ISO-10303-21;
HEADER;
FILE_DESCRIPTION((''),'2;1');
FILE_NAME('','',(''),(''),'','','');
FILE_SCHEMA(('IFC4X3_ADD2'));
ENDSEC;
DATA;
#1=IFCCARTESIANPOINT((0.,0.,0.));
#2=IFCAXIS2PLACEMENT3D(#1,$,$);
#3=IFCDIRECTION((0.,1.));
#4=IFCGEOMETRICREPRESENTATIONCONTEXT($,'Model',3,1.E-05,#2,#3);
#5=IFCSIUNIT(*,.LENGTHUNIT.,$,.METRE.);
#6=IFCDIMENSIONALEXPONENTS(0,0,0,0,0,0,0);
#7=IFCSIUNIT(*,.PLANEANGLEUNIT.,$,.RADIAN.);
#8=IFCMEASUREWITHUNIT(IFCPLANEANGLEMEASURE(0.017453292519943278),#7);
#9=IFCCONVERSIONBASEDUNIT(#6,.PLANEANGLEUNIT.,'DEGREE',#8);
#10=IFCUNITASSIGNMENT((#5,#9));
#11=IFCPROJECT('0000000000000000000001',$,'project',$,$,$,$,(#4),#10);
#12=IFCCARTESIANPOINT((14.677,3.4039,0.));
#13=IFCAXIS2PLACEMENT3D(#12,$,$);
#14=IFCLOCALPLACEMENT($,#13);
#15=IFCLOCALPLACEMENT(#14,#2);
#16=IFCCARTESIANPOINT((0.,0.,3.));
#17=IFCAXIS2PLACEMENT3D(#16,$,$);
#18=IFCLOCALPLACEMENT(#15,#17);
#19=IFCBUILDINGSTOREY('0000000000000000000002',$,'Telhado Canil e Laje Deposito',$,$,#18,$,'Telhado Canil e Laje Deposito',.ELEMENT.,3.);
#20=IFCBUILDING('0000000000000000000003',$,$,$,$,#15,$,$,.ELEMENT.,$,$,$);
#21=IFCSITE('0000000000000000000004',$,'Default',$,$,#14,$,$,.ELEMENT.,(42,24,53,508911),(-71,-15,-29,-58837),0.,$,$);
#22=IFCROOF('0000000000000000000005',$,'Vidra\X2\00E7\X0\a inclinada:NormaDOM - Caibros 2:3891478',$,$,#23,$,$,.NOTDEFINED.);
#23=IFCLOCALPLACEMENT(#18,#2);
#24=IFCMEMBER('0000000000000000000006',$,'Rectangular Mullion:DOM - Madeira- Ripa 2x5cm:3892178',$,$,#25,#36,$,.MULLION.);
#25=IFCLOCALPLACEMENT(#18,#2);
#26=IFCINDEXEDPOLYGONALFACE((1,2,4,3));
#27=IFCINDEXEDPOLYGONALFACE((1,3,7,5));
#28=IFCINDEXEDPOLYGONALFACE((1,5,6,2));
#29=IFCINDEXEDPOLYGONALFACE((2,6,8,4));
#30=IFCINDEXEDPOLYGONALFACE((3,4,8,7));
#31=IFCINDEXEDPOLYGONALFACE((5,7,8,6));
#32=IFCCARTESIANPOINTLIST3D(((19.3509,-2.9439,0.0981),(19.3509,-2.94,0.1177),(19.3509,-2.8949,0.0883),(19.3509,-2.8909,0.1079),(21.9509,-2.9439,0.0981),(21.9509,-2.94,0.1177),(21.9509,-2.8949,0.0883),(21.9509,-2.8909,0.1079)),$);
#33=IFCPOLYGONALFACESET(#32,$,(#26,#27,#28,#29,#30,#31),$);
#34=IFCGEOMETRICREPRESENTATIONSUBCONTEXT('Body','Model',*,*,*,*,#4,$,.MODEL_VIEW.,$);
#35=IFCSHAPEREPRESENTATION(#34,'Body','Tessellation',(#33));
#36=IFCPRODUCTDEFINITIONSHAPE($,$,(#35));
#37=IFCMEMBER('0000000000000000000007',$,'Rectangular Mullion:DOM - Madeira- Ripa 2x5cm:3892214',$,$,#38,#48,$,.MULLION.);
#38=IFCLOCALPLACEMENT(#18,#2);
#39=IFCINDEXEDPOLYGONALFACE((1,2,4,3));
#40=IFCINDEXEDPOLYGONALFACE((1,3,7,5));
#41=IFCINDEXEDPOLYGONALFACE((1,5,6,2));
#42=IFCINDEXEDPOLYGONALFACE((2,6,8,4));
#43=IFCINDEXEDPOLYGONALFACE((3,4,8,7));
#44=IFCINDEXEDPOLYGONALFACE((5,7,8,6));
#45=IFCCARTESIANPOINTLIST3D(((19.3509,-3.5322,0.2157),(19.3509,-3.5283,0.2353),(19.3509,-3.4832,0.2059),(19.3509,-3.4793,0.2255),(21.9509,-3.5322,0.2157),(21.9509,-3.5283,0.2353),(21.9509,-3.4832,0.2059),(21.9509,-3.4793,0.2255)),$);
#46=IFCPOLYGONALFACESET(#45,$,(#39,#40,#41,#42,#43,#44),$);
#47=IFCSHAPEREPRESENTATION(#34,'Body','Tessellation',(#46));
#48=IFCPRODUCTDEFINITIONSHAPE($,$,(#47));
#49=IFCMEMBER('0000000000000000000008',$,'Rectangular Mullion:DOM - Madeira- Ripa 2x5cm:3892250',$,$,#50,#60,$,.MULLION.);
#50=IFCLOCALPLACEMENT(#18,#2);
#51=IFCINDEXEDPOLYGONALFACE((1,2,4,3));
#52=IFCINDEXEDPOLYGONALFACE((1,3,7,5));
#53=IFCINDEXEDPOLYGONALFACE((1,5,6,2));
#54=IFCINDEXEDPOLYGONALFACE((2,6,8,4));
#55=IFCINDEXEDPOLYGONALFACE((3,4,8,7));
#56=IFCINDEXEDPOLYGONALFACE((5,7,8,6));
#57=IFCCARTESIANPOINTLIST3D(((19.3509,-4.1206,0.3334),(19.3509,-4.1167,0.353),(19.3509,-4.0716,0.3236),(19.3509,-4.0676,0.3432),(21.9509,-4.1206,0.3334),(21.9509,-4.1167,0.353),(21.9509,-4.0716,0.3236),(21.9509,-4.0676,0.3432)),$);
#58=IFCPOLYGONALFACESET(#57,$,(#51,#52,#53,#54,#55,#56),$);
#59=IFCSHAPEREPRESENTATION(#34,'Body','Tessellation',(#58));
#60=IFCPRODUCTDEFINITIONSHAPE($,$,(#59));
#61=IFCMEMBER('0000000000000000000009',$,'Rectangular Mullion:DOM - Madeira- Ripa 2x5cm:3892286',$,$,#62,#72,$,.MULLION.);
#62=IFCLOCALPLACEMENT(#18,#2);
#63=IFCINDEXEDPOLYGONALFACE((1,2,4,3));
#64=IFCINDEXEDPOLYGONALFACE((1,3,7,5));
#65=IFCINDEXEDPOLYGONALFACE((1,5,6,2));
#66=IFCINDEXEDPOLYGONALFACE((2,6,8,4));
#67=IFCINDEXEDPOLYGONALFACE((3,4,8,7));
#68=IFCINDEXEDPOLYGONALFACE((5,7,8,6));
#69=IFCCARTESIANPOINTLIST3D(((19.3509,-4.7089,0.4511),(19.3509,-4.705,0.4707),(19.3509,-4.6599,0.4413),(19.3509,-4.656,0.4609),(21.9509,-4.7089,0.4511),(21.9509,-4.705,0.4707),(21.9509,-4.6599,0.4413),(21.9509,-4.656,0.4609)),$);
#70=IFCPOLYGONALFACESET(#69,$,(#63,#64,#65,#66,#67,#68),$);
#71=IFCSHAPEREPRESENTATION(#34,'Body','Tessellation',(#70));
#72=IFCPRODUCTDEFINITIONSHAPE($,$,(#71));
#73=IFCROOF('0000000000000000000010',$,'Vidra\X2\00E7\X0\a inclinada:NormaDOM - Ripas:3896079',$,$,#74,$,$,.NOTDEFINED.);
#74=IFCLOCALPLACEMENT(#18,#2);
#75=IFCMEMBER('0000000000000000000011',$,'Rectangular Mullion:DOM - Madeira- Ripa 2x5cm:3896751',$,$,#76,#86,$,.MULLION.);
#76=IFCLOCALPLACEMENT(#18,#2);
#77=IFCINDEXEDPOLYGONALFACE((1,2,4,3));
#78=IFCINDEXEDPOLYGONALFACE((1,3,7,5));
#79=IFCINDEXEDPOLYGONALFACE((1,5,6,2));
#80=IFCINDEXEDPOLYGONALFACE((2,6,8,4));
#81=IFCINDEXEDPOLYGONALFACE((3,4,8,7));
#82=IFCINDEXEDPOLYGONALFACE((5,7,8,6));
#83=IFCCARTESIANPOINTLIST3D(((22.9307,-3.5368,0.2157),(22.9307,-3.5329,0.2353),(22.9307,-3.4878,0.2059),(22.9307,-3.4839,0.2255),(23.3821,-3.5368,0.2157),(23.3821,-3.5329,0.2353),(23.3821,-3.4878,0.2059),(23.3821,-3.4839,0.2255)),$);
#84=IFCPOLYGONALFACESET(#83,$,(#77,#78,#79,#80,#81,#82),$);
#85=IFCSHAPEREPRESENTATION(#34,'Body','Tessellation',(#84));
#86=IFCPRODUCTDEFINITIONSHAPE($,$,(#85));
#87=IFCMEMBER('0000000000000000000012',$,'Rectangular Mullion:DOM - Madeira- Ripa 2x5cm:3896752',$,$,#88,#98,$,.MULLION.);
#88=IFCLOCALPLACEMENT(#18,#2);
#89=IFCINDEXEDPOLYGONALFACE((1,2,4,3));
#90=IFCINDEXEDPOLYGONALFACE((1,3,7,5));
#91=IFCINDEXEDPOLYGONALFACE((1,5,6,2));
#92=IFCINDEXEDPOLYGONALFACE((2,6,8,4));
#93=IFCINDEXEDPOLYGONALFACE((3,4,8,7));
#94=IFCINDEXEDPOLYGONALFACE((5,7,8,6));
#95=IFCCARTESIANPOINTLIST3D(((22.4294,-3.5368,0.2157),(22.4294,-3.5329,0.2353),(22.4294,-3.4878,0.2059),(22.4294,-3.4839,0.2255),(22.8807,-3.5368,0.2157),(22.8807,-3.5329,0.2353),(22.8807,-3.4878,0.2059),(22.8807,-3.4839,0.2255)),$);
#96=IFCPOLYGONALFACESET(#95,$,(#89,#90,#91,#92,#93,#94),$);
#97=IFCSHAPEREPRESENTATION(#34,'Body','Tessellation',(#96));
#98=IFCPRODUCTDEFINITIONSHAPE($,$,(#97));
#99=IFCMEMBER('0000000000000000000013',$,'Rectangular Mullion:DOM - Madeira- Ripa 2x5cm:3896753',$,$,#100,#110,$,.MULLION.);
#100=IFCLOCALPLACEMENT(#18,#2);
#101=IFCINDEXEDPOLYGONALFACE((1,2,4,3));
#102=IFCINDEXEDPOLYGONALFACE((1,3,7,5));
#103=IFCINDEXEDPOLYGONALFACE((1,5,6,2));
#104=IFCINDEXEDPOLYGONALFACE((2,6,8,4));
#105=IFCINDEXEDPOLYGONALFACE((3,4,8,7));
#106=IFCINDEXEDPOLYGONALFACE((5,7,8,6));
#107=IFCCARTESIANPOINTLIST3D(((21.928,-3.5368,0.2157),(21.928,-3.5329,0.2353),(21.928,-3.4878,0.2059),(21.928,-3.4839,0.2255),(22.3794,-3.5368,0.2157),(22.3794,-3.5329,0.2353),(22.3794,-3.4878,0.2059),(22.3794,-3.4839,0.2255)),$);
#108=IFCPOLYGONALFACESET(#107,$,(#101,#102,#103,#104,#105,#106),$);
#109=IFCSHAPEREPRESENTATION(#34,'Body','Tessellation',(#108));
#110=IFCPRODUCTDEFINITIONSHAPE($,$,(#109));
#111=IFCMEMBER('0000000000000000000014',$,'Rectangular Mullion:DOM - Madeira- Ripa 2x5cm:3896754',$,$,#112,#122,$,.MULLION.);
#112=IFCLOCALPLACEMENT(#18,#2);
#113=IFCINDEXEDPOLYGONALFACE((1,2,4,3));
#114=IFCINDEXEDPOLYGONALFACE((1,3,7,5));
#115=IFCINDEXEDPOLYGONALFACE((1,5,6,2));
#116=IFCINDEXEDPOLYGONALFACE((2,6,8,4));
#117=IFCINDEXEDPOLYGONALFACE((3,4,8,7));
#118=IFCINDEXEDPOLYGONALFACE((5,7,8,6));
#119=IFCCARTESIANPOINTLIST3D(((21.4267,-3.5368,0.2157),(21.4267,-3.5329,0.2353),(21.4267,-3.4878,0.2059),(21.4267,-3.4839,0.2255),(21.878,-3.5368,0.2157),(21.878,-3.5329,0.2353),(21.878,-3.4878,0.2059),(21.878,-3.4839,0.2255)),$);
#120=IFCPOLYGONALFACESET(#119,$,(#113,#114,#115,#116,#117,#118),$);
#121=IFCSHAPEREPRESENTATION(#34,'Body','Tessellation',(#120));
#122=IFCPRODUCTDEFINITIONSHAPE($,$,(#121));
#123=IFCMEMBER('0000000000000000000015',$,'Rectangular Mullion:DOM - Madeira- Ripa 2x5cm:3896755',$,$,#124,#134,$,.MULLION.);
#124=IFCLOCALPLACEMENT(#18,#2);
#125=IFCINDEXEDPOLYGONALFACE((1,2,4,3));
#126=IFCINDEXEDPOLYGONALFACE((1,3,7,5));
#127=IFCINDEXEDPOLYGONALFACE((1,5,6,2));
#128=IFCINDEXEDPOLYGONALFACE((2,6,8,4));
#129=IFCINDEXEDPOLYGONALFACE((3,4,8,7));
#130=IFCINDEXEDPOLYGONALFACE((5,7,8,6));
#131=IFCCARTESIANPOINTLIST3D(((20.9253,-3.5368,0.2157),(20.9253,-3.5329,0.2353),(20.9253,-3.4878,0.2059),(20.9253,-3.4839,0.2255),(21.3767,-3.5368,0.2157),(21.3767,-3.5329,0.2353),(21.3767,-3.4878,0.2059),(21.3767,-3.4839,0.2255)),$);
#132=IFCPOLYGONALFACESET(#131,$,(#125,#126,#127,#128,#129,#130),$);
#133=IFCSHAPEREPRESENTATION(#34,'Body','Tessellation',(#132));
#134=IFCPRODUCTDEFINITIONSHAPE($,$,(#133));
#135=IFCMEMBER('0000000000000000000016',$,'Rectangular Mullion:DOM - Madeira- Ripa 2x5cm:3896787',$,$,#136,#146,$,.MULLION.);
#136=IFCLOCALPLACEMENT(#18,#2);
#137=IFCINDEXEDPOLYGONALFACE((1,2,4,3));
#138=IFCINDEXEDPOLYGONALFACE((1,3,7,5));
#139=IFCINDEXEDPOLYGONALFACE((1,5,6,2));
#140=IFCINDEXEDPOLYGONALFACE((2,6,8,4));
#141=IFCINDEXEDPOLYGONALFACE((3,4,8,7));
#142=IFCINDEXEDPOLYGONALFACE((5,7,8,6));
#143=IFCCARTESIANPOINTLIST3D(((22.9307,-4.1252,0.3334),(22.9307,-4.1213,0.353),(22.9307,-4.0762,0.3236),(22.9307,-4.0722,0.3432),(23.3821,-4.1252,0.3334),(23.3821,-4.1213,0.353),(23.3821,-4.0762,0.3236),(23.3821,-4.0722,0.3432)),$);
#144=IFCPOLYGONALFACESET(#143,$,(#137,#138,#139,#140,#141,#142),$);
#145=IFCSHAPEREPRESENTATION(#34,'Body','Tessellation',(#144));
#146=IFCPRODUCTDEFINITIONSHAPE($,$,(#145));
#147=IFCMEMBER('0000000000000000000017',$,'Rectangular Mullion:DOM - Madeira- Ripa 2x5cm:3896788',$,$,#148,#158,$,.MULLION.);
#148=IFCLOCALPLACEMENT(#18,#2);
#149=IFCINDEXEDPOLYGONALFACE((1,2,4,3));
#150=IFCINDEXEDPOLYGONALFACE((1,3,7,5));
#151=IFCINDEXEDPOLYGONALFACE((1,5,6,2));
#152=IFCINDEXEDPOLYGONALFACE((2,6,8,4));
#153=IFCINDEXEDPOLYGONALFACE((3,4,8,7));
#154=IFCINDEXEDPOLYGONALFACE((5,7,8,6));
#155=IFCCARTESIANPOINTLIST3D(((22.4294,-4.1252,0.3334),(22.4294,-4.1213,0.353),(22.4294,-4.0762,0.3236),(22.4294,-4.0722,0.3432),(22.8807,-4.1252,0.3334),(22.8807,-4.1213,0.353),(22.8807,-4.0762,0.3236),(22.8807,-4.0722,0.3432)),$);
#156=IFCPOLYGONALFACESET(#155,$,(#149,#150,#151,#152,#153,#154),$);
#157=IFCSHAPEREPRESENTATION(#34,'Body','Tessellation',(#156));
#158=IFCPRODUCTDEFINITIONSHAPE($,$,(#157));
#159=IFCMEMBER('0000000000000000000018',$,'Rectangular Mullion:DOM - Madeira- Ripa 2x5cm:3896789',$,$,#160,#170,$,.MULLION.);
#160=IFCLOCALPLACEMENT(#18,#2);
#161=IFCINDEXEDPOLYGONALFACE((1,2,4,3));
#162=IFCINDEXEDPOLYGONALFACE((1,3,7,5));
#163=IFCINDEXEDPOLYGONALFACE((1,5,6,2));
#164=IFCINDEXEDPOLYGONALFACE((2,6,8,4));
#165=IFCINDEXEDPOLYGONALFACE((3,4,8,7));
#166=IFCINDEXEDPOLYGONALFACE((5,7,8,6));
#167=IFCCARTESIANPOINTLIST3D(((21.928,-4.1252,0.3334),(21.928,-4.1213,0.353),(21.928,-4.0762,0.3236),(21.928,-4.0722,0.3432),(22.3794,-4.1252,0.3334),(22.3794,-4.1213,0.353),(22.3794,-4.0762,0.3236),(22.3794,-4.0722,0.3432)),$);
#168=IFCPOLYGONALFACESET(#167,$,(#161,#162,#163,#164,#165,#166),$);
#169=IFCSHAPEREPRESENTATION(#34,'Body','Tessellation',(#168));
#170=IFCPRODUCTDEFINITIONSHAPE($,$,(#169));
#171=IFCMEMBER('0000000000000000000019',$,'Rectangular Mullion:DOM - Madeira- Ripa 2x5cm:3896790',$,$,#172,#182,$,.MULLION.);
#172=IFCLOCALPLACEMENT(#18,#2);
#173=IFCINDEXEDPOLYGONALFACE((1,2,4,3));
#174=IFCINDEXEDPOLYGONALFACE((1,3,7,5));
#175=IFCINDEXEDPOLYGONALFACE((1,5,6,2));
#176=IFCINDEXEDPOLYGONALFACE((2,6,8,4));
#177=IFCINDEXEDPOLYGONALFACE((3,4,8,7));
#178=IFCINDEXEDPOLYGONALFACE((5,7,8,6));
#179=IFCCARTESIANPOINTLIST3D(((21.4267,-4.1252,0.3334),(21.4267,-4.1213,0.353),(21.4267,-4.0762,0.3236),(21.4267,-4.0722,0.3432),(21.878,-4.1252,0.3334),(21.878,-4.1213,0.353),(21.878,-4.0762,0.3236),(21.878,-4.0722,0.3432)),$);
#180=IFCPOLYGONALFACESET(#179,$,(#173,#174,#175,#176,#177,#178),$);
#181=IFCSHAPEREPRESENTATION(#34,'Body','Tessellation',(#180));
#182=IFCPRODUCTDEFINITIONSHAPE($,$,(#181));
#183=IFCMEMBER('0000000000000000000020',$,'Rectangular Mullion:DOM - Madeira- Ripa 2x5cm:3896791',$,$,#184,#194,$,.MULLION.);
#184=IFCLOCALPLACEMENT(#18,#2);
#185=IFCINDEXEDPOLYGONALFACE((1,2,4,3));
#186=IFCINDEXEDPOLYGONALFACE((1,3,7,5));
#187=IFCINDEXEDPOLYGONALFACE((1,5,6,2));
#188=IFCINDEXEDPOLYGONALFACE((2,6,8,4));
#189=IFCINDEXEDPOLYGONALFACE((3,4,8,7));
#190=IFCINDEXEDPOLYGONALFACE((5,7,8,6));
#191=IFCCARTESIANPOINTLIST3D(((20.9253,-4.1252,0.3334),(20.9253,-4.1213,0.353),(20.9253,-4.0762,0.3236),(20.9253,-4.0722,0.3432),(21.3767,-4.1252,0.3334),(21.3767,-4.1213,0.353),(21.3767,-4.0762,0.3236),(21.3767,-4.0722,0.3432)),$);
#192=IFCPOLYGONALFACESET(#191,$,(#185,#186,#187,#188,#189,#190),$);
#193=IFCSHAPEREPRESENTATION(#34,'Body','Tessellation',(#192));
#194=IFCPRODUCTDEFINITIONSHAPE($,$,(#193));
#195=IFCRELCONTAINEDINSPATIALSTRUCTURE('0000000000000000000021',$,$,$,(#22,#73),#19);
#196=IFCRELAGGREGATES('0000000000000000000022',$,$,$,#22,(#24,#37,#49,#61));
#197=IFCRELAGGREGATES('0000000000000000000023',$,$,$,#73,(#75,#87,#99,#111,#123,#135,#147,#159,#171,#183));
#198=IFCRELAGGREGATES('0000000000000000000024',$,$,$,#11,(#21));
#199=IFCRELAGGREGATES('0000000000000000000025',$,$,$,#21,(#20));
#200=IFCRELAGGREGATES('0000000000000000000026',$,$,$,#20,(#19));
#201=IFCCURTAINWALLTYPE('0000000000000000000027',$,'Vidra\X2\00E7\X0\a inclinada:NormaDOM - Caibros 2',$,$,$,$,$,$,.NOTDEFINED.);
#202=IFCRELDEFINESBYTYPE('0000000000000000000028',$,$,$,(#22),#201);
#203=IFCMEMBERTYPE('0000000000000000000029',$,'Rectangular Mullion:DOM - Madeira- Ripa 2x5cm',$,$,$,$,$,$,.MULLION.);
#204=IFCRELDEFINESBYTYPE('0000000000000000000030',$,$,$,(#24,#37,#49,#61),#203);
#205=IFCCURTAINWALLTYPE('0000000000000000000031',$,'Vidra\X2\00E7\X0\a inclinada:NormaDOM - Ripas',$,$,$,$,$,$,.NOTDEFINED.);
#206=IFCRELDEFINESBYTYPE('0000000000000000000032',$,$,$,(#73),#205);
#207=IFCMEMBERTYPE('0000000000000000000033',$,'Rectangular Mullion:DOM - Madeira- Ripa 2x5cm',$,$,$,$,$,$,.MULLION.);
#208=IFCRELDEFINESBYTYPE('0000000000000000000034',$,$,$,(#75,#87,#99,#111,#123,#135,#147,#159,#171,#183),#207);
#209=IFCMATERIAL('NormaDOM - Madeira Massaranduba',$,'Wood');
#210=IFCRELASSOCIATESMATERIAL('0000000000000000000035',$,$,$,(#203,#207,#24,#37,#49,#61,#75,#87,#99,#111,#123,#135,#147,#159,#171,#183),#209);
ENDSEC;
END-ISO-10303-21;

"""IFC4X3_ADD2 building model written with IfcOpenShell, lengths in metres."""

from ifc_helpers import new_model, entity, si_unit, converted_unit, direction, frame, origin, origin_2d_with_axis, place, context, subcontext, project, spatial, rectangle, extrude, source, transform, mapped, material, material_profile, profile_set, profile_usage, type_object, type_shapes, element, aggregate, save


model = new_model("IFC4X3_ADD2")

# Units and contexts
model_context = context("Model", 3, precision=1e-05, world=origin(), true_north=direction((0.0, 1.0)))
body_context = subcontext(model_context, "Body", "Model", "MODEL_VIEW")
ifc_project = project(units=[si_unit("LENGTHUNIT", "METRE"), converted_unit("PLANEANGLEUNIT", "DEGREE", entity("IfcPlaneAngleMeasure", 0.017453292519943278), si_unit("PLANEANGLEUNIT", "RADIAN"), dimensions=[0, 0, 0, 0, 0, 0, 0])], contexts=[model_context])

# Site, building, storey
site_placement = place(None, frame((14.677, 3.4039, 0.0)))
site = spatial("IfcSite", under=ifc_project, at=site_placement, Name="Default", CompositionType="ELEMENT", RefLatitude=(42, 24, 53, 508911), RefLongitude=(-71, -15, -29, -58837), RefElevation=0.0)
building_placement = place(site_placement, origin())
building = spatial("IfcBuilding", under=site, at=building_placement, CompositionType="ELEMENT")
storey_placement = place(building_placement, frame((0.0, 0.0, 3.0)))
storey = spatial("IfcBuildingStorey", under=building, at=storey_placement, Name="Telhado Canil e Laje Deposito", LongName="Telhado Canil e Laje Deposito", CompositionType="ELEMENT", Elevation=3.0)

# Roofs, members
curtain_wall_type_1 = type_object("IfcCurtainWallType", Name="Vidraça inclinada:NormaDOM - Caibros 2", PredefinedType="NOTDEFINED")
roof_1_placement = place(storey_placement, frame((0.0, 0.0, -3.0)))
roof_1 = element("IfcRoof", 1, at=roof_1_placement, inside=storey, type_object=curtain_wall_type_1, Name="Vidraça inclinada:NormaDOM - Caibros 2:3891478", PredefinedType="NOTDEFINED")
ifc_material = material(Name="NormaDOM - Madeira Massaranduba", Category="Wood")
ifc_material_profile_1 = material_profile(ifc_material, rectangle(XDim=0.05, YDim=0.02, at=origin_2d_with_axis()), Name="DOM - Madeira- Ripa 2x5cm")
ifc_profile_set_1 = profile_set([ifc_material_profile_1], Name="DOM - Madeira- Ripa 2x5cm")
ifc_profile_usage_1 = profile_usage(ifc_profile_set_1)
member_type_1 = type_object("IfcMemberType", Name="Rectangular Mullion:DOM - Madeira- Ripa 2x5cm", PredefinedType="MULLION", material=ifc_profile_set_1)
shared_shape_1 = source(origin(), body_context, "Body", "SweptSolid", [
    extrude(rectangle(XDim=0.05, YDim=0.02, at=origin_2d_with_axis()), frame((0.025, 0.01, -2.6), z_axis=(0.0, 0.0, 1.0), x_axis=(-1.0, 0.0, 0.0)), (0.0, 0.0, 1.0), 2.6),
])
type_shapes(member_type_1, [shared_shape_1])
member_1_placement = place(roof_1_placement, frame((21.9509, -2.8909, 3.1079), z_axis=(1.0, 0.0, 0.0), x_axis=(0.0, -0.980581, 0.196116)))
member_1 = element("IfcMember", 2, at=member_1_placement, type_object=member_type_1, material=ifc_profile_usage_1, Name="Rectangular Mullion:DOM - Madeira- Ripa 2x5cm:3892178", PredefinedType="MULLION", context=body_context, shape_type="MappedRepresentation", body=[
    mapped(shared_shape_1, transform((0.0, 0.0, 0.0), scale=1.0)),
])
member_2_placement = place(roof_1_placement, frame((21.9509, -3.4793, 3.2255), z_axis=(1.0, 0.0, 0.0), x_axis=(0.0, -0.980581, 0.196116)))
member_2 = element("IfcMember", 3, at=member_2_placement, type_object=member_type_1, material=ifc_profile_usage_1, Name="Rectangular Mullion:DOM - Madeira- Ripa 2x5cm:3892214", PredefinedType="MULLION", context=body_context, shape_type="MappedRepresentation", body=[
    mapped(shared_shape_1, transform((0.0, 0.0, 0.0), scale=1.0)),
])
member_3_placement = place(roof_1_placement, frame((21.9509, -4.0676, 3.3432), z_axis=(1.0, 0.0, 0.0), x_axis=(0.0, -0.980581, 0.196116)))
member_3 = element("IfcMember", 4, at=member_3_placement, type_object=member_type_1, material=ifc_profile_usage_1, Name="Rectangular Mullion:DOM - Madeira- Ripa 2x5cm:3892250", PredefinedType="MULLION", context=body_context, shape_type="MappedRepresentation", body=[
    mapped(shared_shape_1, transform((0.0, 0.0, 0.0), scale=1.0)),
])
member_4_placement = place(roof_1_placement, frame((21.9509, -4.656, 3.4609), z_axis=(1.0, 0.0, 0.0), x_axis=(0.0, -0.980581, 0.196116)))
member_4 = element("IfcMember", 5, at=member_4_placement, type_object=member_type_1, material=ifc_profile_usage_1, Name="Rectangular Mullion:DOM - Madeira- Ripa 2x5cm:3892286", PredefinedType="MULLION", context=body_context, shape_type="MappedRepresentation", body=[
    mapped(shared_shape_1, transform((0.0, 0.0, 0.0), scale=1.0)),
])
curtain_wall_type_2 = type_object("IfcCurtainWallType", Name="Vidraça inclinada:NormaDOM - Ripas", PredefinedType="NOTDEFINED")
roof_2_placement = place(storey_placement, frame((0.0, 0.0, -3.0)))
roof_2 = element("IfcRoof", 6, at=roof_2_placement, inside=storey, type_object=curtain_wall_type_2, Name="Vidraça inclinada:NormaDOM - Ripas:3896079", PredefinedType="NOTDEFINED")

# Members
aggregate(roof_1, [member_1, member_2, member_3, member_4])
member_type_2 = type_object("IfcMemberType", Name="Rectangular Mullion:DOM - Madeira- Ripa 2x5cm", PredefinedType="MULLION", material=ifc_profile_set_1)
shared_shape_2 = source(origin(), body_context, "Body", "SweptSolid", [
    extrude(rectangle(XDim=0.05, YDim=0.02, at=origin_2d_with_axis()), frame((0.025, 0.01, -0.4514), z_axis=(0.0, 0.0, 1.0), x_axis=(-1.0, 0.0, 0.0)), (0.0, 0.0, 1.0), 0.4514),
])
type_shapes(member_type_2, [shared_shape_2])
member_5_placement = place(roof_2_placement, frame((23.3821, -3.4839, 3.2255), z_axis=(1.0, 0.0, 0.0), x_axis=(0.0, -0.980581, 0.196116)))
member_5 = element("IfcMember", 7, at=member_5_placement, type_object=member_type_2, material=ifc_profile_usage_1, Name="Rectangular Mullion:DOM - Madeira- Ripa 2x5cm:3896751", PredefinedType="MULLION", context=body_context, shape_type="MappedRepresentation", body=[
    mapped(shared_shape_2, transform((0.0, 0.0, 0.0), scale=1.0)),
])
member_6_placement = place(roof_2_placement, frame((22.8807, -3.4839, 3.2255), z_axis=(1.0, 0.0, 0.0), x_axis=(0.0, -0.980581, 0.196116)))
member_6 = element("IfcMember", 8, at=member_6_placement, type_object=member_type_2, material=ifc_profile_usage_1, Name="Rectangular Mullion:DOM - Madeira- Ripa 2x5cm:3896752", PredefinedType="MULLION", context=body_context, shape_type="MappedRepresentation", body=[
    mapped(shared_shape_2, transform((0.0, 0.0, 0.0), scale=1.0)),
])
member_7_placement = place(roof_2_placement, frame((22.3794, -3.4839, 3.2255), z_axis=(1.0, 0.0, 0.0), x_axis=(0.0, -0.980581, 0.196116)))
member_7 = element("IfcMember", 9, at=member_7_placement, type_object=member_type_2, material=ifc_profile_usage_1, Name="Rectangular Mullion:DOM - Madeira- Ripa 2x5cm:3896753", PredefinedType="MULLION", context=body_context, shape_type="MappedRepresentation", body=[
    mapped(shared_shape_2, transform((0.0, 0.0, 0.0), scale=1.0)),
])
member_8_placement = place(roof_2_placement, frame((21.878, -3.4839, 3.2255), z_axis=(1.0, 0.0, 0.0), x_axis=(0.0, -0.980581, 0.196116)))
member_8 = element("IfcMember", 10, at=member_8_placement, type_object=member_type_2, material=ifc_profile_usage_1, Name="Rectangular Mullion:DOM - Madeira- Ripa 2x5cm:3896754", PredefinedType="MULLION", context=body_context, shape_type="MappedRepresentation", body=[
    mapped(shared_shape_2, transform((0.0, 0.0, 0.0), scale=1.0)),
])
member_9_placement = place(roof_2_placement, frame((21.3767, -3.4839, 3.2255), z_axis=(1.0, 0.0, 0.0), x_axis=(0.0, -0.980581, 0.196116)))
member_9 = element("IfcMember", 11, at=member_9_placement, type_object=member_type_2, material=ifc_profile_usage_1, Name="Rectangular Mullion:DOM - Madeira- Ripa 2x5cm:3896755", PredefinedType="MULLION", context=body_context, shape_type="MappedRepresentation", body=[
    mapped(shared_shape_2, transform((0.0, 0.0, 0.0), scale=1.0)),
])
member_10_placement = place(roof_2_placement, frame((23.3821, -4.0722, 3.3432), z_axis=(1.0, 0.0, 0.0), x_axis=(0.0, -0.980581, 0.196116)))
member_10 = element("IfcMember", 12, at=member_10_placement, type_object=member_type_2, material=ifc_profile_usage_1, Name="Rectangular Mullion:DOM - Madeira- Ripa 2x5cm:3896787", PredefinedType="MULLION", context=body_context, shape_type="MappedRepresentation", body=[
    mapped(shared_shape_2, transform((0.0, 0.0, 0.0), scale=1.0)),
])
member_11_placement = place(roof_2_placement, frame((22.8807, -4.0722, 3.3432), z_axis=(1.0, 0.0, 0.0), x_axis=(0.0, -0.980581, 0.196116)))
member_11 = element("IfcMember", 13, at=member_11_placement, type_object=member_type_2, material=ifc_profile_usage_1, Name="Rectangular Mullion:DOM - Madeira- Ripa 2x5cm:3896788", PredefinedType="MULLION", context=body_context, shape_type="MappedRepresentation", body=[
    mapped(shared_shape_2, transform((0.0, 0.0, 0.0), scale=1.0)),
])
member_12_placement = place(roof_2_placement, frame((22.3794, -4.0722, 3.3432), z_axis=(1.0, 0.0, 0.0), x_axis=(0.0, -0.980581, 0.196116)))
member_12 = element("IfcMember", 14, at=member_12_placement, type_object=member_type_2, material=ifc_profile_usage_1, Name="Rectangular Mullion:DOM - Madeira- Ripa 2x5cm:3896789", PredefinedType="MULLION", context=body_context, shape_type="MappedRepresentation", body=[
    mapped(shared_shape_2, transform((0.0, 0.0, 0.0), scale=1.0)),
])
member_13_placement = place(roof_2_placement, frame((21.878, -4.0722, 3.3432), z_axis=(1.0, 0.0, 0.0), x_axis=(0.0, -0.980581, 0.196116)))
member_13 = element("IfcMember", 15, at=member_13_placement, type_object=member_type_2, material=ifc_profile_usage_1, Name="Rectangular Mullion:DOM - Madeira- Ripa 2x5cm:3896790", PredefinedType="MULLION", context=body_context, shape_type="MappedRepresentation", body=[
    mapped(shared_shape_2, transform((0.0, 0.0, 0.0), scale=1.0)),
])
member_14_placement = place(roof_2_placement, frame((21.3767, -4.0722, 3.3432), z_axis=(1.0, 0.0, 0.0), x_axis=(0.0, -0.980581, 0.196116)))
member_14 = element("IfcMember", 16, at=member_14_placement, type_object=member_type_2, material=ifc_profile_usage_1, Name="Rectangular Mullion:DOM - Madeira- Ripa 2x5cm:3896791", PredefinedType="MULLION", context=body_context, shape_type="MappedRepresentation", body=[
    mapped(shared_shape_2, transform((0.0, 0.0, 0.0), scale=1.0)),
])
aggregate(roof_2, [member_5, member_6, member_7, member_8, member_9, member_10, member_11, member_12, member_13, member_14])

save(model, "model.ifc")
